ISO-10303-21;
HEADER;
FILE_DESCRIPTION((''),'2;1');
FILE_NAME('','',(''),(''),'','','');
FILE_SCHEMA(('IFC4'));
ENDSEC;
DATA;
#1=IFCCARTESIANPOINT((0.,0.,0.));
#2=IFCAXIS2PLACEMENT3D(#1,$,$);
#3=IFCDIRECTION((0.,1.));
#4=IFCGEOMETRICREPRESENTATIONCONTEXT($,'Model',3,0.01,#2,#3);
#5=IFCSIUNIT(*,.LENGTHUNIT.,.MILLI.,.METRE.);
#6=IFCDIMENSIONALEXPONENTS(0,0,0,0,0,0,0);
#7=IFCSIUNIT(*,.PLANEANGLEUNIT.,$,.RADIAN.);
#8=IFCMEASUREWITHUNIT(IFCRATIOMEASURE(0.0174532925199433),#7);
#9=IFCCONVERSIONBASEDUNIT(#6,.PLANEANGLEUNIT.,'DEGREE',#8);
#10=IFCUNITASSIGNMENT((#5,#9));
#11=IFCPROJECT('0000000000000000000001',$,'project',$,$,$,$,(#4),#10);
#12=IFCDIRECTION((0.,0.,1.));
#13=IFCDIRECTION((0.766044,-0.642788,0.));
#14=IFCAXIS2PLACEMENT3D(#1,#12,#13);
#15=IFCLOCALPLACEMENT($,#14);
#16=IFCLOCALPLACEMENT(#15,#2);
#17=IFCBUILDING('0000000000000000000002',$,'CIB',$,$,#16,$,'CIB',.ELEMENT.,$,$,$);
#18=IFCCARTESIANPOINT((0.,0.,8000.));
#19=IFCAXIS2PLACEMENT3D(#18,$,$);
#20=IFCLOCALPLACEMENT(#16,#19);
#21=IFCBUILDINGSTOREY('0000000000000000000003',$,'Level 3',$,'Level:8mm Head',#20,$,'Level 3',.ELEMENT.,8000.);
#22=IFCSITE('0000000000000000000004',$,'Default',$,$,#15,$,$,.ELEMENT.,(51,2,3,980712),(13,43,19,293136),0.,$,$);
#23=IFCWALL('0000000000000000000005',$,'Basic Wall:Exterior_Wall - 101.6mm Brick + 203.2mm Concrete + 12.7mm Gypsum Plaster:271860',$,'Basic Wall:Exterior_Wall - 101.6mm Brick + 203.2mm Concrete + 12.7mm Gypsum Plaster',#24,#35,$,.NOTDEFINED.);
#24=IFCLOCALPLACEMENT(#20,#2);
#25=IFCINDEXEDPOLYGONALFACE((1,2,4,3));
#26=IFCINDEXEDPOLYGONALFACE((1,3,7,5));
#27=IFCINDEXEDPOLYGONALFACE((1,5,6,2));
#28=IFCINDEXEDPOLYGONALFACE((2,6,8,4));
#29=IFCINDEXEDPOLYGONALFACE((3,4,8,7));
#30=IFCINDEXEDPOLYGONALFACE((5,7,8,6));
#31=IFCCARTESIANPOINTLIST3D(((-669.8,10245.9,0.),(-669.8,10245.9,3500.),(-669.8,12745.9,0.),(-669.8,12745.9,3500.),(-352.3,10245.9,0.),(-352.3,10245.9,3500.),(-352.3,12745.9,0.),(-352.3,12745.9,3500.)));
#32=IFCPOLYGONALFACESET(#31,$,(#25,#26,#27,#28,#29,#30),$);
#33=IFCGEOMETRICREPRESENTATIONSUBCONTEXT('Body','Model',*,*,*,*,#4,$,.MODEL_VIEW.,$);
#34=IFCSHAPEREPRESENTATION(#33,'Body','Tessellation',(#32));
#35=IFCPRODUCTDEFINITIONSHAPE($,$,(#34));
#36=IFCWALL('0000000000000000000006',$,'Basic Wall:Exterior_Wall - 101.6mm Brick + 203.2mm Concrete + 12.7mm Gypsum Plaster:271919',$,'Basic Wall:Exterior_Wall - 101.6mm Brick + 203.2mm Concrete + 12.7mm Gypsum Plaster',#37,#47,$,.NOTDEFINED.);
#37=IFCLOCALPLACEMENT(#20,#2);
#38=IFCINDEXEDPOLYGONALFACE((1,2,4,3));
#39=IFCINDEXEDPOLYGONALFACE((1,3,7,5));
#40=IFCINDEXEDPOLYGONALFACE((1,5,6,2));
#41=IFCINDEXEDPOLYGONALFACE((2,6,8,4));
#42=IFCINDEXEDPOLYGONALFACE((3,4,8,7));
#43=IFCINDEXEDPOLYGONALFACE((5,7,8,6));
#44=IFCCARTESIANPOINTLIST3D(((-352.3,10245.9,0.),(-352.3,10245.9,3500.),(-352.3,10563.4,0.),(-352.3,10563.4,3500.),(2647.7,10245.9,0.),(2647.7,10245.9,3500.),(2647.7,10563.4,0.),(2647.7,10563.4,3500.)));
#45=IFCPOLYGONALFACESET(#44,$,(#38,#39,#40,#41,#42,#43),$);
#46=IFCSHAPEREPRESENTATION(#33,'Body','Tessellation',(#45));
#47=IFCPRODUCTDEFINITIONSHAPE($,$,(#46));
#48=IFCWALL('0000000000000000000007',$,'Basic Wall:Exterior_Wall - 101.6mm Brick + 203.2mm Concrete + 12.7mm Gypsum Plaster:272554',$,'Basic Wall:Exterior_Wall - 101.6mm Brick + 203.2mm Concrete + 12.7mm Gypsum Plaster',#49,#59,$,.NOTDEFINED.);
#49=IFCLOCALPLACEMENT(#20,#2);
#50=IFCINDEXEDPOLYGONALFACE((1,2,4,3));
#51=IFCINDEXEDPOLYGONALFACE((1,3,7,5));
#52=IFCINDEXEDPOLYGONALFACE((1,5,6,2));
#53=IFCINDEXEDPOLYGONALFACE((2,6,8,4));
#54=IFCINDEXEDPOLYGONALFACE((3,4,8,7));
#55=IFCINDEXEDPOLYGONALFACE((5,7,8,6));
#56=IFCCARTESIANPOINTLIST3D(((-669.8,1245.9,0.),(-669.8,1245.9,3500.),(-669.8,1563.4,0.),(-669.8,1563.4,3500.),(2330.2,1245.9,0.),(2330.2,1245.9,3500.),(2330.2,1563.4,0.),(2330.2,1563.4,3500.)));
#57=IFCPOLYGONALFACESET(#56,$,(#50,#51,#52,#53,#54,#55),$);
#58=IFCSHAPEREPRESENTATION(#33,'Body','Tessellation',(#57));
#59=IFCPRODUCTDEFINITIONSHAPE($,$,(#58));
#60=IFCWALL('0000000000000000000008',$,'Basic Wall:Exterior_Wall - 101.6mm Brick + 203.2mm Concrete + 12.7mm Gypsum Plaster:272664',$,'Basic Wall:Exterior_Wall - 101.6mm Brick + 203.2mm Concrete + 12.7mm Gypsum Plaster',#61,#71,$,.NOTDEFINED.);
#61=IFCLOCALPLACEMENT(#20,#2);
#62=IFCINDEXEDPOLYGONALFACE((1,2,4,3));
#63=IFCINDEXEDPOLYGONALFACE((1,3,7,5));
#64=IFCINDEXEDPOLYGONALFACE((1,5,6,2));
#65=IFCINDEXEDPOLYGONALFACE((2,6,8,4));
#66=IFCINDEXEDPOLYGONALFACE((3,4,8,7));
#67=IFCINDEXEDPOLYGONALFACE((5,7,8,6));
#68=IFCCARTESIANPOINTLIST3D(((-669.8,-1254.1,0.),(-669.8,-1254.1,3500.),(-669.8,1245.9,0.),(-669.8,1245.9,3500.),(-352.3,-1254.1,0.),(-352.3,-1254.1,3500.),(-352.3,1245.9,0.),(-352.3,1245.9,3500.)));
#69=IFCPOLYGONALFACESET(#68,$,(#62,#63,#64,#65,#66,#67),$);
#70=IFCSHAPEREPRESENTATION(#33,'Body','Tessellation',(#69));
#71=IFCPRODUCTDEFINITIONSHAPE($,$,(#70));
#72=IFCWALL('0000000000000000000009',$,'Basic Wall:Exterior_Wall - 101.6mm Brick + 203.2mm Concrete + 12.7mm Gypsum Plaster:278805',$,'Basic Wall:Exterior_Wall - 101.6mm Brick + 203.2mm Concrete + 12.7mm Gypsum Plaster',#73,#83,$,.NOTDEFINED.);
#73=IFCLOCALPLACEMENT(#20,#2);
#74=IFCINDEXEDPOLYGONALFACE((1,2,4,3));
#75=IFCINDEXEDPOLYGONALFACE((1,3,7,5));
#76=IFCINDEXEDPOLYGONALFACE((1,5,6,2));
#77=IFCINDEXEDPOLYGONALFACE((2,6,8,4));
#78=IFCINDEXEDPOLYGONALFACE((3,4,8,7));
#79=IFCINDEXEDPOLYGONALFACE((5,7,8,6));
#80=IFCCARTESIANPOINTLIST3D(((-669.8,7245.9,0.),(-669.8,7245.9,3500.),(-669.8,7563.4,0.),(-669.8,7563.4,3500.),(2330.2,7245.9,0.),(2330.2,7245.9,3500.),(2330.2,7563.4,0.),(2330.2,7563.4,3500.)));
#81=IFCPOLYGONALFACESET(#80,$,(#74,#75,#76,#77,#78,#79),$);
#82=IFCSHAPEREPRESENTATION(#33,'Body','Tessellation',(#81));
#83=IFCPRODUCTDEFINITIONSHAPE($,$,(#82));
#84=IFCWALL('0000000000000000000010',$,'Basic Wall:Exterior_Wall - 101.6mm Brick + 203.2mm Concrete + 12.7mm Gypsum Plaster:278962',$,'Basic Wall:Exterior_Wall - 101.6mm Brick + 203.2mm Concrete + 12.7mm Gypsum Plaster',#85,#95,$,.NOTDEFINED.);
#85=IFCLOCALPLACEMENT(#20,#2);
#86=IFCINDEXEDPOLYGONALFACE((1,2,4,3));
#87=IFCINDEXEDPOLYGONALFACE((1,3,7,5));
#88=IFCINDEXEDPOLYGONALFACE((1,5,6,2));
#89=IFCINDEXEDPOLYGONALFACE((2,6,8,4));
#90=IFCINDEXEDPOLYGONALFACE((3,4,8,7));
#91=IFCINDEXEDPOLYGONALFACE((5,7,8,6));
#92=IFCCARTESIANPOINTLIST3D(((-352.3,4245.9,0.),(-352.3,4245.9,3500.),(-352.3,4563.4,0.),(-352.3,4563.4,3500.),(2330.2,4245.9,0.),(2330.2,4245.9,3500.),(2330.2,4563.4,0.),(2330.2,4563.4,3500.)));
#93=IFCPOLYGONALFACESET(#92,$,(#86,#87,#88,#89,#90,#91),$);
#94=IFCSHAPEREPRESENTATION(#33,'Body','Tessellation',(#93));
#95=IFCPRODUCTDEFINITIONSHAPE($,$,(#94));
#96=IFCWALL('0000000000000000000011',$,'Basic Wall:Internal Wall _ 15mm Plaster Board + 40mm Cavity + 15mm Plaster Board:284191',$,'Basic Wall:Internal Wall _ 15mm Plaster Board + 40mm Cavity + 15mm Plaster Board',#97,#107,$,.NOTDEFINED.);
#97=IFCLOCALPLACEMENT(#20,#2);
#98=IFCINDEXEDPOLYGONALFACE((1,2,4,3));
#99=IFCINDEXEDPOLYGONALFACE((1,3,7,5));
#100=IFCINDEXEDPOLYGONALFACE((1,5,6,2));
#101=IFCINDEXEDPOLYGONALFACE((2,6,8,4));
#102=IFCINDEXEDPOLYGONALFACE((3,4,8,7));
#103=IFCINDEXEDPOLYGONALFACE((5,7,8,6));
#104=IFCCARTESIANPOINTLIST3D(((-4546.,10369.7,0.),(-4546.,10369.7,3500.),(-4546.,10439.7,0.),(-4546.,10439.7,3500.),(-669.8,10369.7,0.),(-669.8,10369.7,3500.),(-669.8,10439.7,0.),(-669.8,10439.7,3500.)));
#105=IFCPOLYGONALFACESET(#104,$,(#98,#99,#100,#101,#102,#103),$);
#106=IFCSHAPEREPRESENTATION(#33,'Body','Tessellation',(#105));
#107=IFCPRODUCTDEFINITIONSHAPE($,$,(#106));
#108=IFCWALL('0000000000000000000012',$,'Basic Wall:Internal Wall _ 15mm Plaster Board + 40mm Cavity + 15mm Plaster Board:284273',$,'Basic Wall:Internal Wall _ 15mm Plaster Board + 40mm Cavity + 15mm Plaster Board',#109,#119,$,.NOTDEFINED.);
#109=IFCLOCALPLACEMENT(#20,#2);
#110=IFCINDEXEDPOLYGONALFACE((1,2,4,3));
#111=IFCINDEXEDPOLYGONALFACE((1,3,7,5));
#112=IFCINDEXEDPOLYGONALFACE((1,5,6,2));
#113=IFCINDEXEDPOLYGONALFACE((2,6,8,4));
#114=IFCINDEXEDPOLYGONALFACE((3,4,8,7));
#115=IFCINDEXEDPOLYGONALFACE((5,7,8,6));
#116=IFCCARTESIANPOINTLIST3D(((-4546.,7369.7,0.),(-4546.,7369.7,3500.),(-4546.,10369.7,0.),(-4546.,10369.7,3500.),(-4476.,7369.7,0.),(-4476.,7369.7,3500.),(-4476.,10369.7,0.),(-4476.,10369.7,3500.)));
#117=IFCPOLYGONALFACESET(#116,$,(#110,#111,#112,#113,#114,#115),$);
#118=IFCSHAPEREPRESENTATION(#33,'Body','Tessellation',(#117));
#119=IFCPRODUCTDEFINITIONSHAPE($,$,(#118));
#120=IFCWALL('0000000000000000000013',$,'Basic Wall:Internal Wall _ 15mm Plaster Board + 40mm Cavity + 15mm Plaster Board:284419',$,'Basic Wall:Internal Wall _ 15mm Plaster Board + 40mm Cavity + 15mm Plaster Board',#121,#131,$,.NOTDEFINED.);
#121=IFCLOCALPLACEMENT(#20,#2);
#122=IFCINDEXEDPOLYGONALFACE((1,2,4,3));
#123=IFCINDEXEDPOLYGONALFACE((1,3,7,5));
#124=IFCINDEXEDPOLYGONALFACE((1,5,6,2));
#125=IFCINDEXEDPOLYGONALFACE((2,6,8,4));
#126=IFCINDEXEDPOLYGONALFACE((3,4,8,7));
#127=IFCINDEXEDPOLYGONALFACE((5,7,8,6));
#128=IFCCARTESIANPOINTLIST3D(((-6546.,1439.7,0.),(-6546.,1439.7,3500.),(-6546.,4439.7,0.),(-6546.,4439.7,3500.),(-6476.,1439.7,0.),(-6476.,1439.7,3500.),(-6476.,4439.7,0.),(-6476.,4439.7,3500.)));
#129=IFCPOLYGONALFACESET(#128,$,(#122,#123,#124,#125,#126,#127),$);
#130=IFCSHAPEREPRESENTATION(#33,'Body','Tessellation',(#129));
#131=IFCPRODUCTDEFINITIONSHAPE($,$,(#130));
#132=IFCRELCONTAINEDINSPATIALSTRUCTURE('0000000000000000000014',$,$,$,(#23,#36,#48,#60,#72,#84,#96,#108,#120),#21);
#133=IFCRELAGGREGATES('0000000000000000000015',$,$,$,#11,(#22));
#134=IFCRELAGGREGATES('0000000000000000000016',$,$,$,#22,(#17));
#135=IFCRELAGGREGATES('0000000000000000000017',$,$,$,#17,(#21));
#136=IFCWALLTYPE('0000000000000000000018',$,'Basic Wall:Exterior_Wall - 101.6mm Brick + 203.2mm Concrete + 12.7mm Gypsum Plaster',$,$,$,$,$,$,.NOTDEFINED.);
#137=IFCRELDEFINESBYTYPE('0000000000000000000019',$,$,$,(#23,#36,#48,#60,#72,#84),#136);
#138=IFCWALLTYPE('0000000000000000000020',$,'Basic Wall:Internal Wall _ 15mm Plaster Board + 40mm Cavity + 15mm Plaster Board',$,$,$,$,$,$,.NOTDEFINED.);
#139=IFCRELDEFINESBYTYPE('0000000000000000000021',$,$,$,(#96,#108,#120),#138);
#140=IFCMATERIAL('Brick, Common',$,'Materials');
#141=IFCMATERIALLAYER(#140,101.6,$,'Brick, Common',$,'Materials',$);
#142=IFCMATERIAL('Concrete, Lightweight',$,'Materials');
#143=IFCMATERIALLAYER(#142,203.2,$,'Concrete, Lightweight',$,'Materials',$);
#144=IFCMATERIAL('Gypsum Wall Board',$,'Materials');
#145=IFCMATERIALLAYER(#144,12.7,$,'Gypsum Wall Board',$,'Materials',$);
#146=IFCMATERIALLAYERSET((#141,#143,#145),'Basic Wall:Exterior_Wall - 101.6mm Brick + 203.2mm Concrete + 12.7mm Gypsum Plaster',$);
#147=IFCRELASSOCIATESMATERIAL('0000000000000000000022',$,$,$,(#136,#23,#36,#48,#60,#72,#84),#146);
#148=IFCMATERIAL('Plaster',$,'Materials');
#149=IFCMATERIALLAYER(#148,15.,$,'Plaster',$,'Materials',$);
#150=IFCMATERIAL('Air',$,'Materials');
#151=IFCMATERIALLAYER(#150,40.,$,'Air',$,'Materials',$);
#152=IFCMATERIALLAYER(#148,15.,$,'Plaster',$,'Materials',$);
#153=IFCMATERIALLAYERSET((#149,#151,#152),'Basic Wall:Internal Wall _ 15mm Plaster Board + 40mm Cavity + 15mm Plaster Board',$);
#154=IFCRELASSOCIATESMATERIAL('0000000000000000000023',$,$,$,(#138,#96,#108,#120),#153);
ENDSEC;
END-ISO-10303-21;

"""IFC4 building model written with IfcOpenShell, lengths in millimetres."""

from ifc_helpers import new_model, entity, si_unit, converted_unit, direction, frame, origin, place, context, subcontext, project, spatial, indexed_curve, outline, extrude, material, layer, layer_set, type_object, element, save


model = new_model("IFC4")

# Units and contexts
model_context = context("Model", 3, precision=0.01, world=origin(), true_north=direction((0.0, 1.0)))
body_context = subcontext(model_context, "Body", "Model", "MODEL_VIEW")
ifc_project = project(units=[si_unit("LENGTHUNIT", "METRE", prefix="MILLI"), converted_unit("PLANEANGLEUNIT", "DEGREE", entity("IfcRatioMeasure", 0.0174532925199433), si_unit("PLANEANGLEUNIT", "RADIAN"), dimensions=[0, 0, 0, 0, 0, 0, 0])], contexts=[model_context])

# Site, building, storey
site_placement = place(None, frame((0.0, 0.0, 0.0), z_axis=(0.0, 0.0, 1.0), x_axis=(0.766044, -0.642788, 0.0)))
site = spatial("IfcSite", under=ifc_project, at=site_placement, Name="Default", CompositionType="ELEMENT", RefLatitude=(51, 2, 3, 980712), RefLongitude=(13, 43, 19, 293136), RefElevation=0.0)
building_placement = place(site_placement, origin())
building = spatial("IfcBuilding", under=site, at=building_placement, Name="CIB", LongName="CIB", CompositionType="ELEMENT")
storey_placement = place(building_placement, frame((0.0, 0.0, 8000.0)))
storey = spatial("IfcBuildingStorey", under=building, at=storey_placement, Name="Level 3", ObjectType="Level:8mm Head", LongName="Level 3", CompositionType="ELEMENT", Elevation=8000.0)

# Shared definitions
ifc_material_1 = material(Name="Plaster", Category="Materials")

# Walls
ifc_material_2 = material(Name="Brick, Common", Category="Materials")
ifc_layer_1 = layer(ifc_material_2, 101.6, Name="Brick, Common", Category="Materials")
ifc_material_3 = material(Name="Concrete, Lightweight", Category="Materials")
ifc_layer_2 = layer(ifc_material_3, 203.2, Name="Concrete, Lightweight", Category="Materials")
ifc_material_4 = material(Name="Gypsum Wall Board", Category="Materials")
ifc_layer_3 = layer(ifc_material_4, 12.7, Name="Gypsum Wall Board", Category="Materials")
ifc_layer_set_1 = layer_set([ifc_layer_1, ifc_layer_2, ifc_layer_3], Name="Basic Wall:Exterior_Wall - 101.6mm Brick + 203.2mm Concrete + 12.7mm Gypsum Plaster")
wall_type_1 = type_object("IfcWallType", Name="Basic Wall:Exterior_Wall - 101.6mm Brick + 203.2mm Concrete + 12.7mm Gypsum Plaster", PredefinedType="NOTDEFINED", material=ifc_layer_set_1)
wall_1_placement = place(storey_placement, frame((-511.0, 12745.9, 0.0), z_axis=(0.0, 0.0, 1.0), x_axis=(0.0, -1.0, 0.0)))
element("IfcWall", 1, at=wall_1_placement, inside=storey, type_object=wall_type_1, material=ifc_layer_set_1, Name="Basic Wall:Exterior_Wall - 101.6mm Brick + 203.2mm Concrete + 12.7mm Gypsum Plaster:271860", ObjectType="Basic Wall:Exterior_Wall - 101.6mm Brick + 203.2mm Concrete + 12.7mm Gypsum Plaster", PredefinedType="NOTDEFINED", context=body_context, shape_type="SweptSolid", body=[
    extrude(outline(indexed_curve([(2500.0, 158.8), (0.0, 158.8), (0.0, -158.8), (2500.0, -158.8), (2500.0, 158.8)], self_intersect=False)), origin(), (0.0, 0.0, 1.0), 3500.0),
])
wall_2_placement = place(storey_placement, frame((-352.3, 10404.7, 0.0)))
element("IfcWall", 2, at=wall_2_placement, inside=storey, type_object=wall_type_1, material=ifc_layer_set_1, Name="Basic Wall:Exterior_Wall - 101.6mm Brick + 203.2mm Concrete + 12.7mm Gypsum Plaster:271919", ObjectType="Basic Wall:Exterior_Wall - 101.6mm Brick + 203.2mm Concrete + 12.7mm Gypsum Plaster", PredefinedType="NOTDEFINED", context=body_context, shape_type="SweptSolid", body=[
    extrude(outline(indexed_curve([(3000.0, 158.8), (0.0, 158.8), (0.0, -158.8), (3000.0, -158.8), (3000.0, 158.8)], self_intersect=False)), origin(), (0.0, 0.0, 1.0), 3500.0),
])
wall_3_placement = place(storey_placement, frame((2330.2, 1404.7, 0.0), z_axis=(0.0, 0.0, 1.0), x_axis=(-1.0, 0.0, 0.0)))
element("IfcWall", 3, at=wall_3_placement, inside=storey, type_object=wall_type_1, material=ifc_layer_set_1, Name="Basic Wall:Exterior_Wall - 101.6mm Brick + 203.2mm Concrete + 12.7mm Gypsum Plaster:272554", ObjectType="Basic Wall:Exterior_Wall - 101.6mm Brick + 203.2mm Concrete + 12.7mm Gypsum Plaster", PredefinedType="NOTDEFINED", context=body_context, shape_type="SweptSolid", body=[
    extrude(outline(indexed_curve([(3000.0, 158.8), (0.0, 158.8), (0.0, -158.8), (3000.0, -158.8), (3000.0, 158.8)], self_intersect=False)), origin(), (0.0, 0.0, 1.0), 3500.0),
])
wall_4_placement = place(storey_placement, frame((-511.0, 1245.9, 0.0), z_axis=(0.0, 0.0, 1.0), x_axis=(0.0, -1.0, 0.0)))
element("IfcWall", 4, at=wall_4_placement, inside=storey, type_object=wall_type_1, material=ifc_layer_set_1, Name="Basic Wall:Exterior_Wall - 101.6mm Brick + 203.2mm Concrete + 12.7mm Gypsum Plaster:272664", ObjectType="Basic Wall:Exterior_Wall - 101.6mm Brick + 203.2mm Concrete + 12.7mm Gypsum Plaster", PredefinedType="NOTDEFINED", context=body_context, shape_type="SweptSolid", body=[
    extrude(outline(indexed_curve([(2500.0, 158.8), (0.0, 158.8), (0.0, -158.8), (2500.0, -158.8), (2500.0, 158.8)], self_intersect=False)), origin(), (0.0, 0.0, 1.0), 3500.0),
])
wall_5_placement = place(storey_placement, frame((2330.2, 7404.7, 0.0), z_axis=(0.0, 0.0, 1.0), x_axis=(-1.0, 0.0, 0.0)))
element("IfcWall", 5, at=wall_5_placement, inside=storey, type_object=wall_type_1, material=ifc_layer_set_1, Name="Basic Wall:Exterior_Wall - 101.6mm Brick + 203.2mm Concrete + 12.7mm Gypsum Plaster:278805", ObjectType="Basic Wall:Exterior_Wall - 101.6mm Brick + 203.2mm Concrete + 12.7mm Gypsum Plaster", PredefinedType="NOTDEFINED", context=body_context, shape_type="SweptSolid", body=[
    extrude(outline(indexed_curve([(3000.0, 158.8), (0.0, 158.8), (0.0, -158.8), (3000.0, -158.8), (3000.0, 158.8)], self_intersect=False)), origin(), (0.0, 0.0, 1.0), 3500.0),
])
wall_6_placement = place(storey_placement, frame((-352.3, 4404.7, 0.0)))
element("IfcWall", 6, at=wall_6_placement, inside=storey, type_object=wall_type_1, material=ifc_layer_set_1, Name="Basic Wall:Exterior_Wall - 101.6mm Brick + 203.2mm Concrete + 12.7mm Gypsum Plaster:278962", ObjectType="Basic Wall:Exterior_Wall - 101.6mm Brick + 203.2mm Concrete + 12.7mm Gypsum Plaster", PredefinedType="NOTDEFINED", context=body_context, shape_type="SweptSolid", body=[
    extrude(outline(indexed_curve([(2682.5, 158.8), (0.0, 158.8), (0.0, -158.8), (2682.5, -158.8), (2682.5, 158.8)], self_intersect=False)), origin(), (0.0, 0.0, 1.0), 3500.0),
])
ifc_layer_4 = layer(ifc_material_1, 15.0, Name="Plaster", Category="Materials")
ifc_material_5 = material(Name="Air", Category="Materials")
ifc_layer_5 = layer(ifc_material_5, 40.0, Name="Air", Category="Materials")
ifc_layer_6 = layer(ifc_material_1, 15.0, Name="Plaster", Category="Materials")
ifc_layer_set_2 = layer_set([ifc_layer_4, ifc_layer_5, ifc_layer_6], Name="Basic Wall:Internal Wall _ 15mm Plaster Board + 40mm Cavity + 15mm Plaster Board")
wall_type_2 = type_object("IfcWallType", Name="Basic Wall:Internal Wall _ 15mm Plaster Board + 40mm Cavity + 15mm Plaster Board", PredefinedType="NOTDEFINED", material=ifc_layer_set_2)
wall_7_placement = place(storey_placement, frame((-669.8, 10404.7, 0.0), z_axis=(0.0, 0.0, 1.0), x_axis=(-1.0, 0.0, 0.0)))
element("IfcWall", 7, at=wall_7_placement, inside=storey, type_object=wall_type_2, material=ifc_layer_set_2, Name="Basic Wall:Internal Wall _ 15mm Plaster Board + 40mm Cavity + 15mm Plaster Board:284191", ObjectType="Basic Wall:Internal Wall _ 15mm Plaster Board + 40mm Cavity + 15mm Plaster Board", PredefinedType="NOTDEFINED", context=body_context, shape_type="SweptSolid", body=[
    extrude(outline(indexed_curve([(3876.2, 35.0), (0.0, 35.0), (0.0, -35.0), (3876.2, -35.0), (3876.2, 35.0)], self_intersect=False)), origin(), (0.0, 0.0, 1.0), 3500.0),
])
wall_8_placement = place(storey_placement, frame((-4511.0, 10369.7, 0.0), z_axis=(0.0, 0.0, 1.0), x_axis=(0.0, -1.0, 0.0)))
element("IfcWall", 8, at=wall_8_placement, inside=storey, type_object=wall_type_2, material=ifc_layer_set_2, Name="Basic Wall:Internal Wall _ 15mm Plaster Board + 40mm Cavity + 15mm Plaster Board:284273", ObjectType="Basic Wall:Internal Wall _ 15mm Plaster Board + 40mm Cavity + 15mm Plaster Board", PredefinedType="NOTDEFINED", context=body_context, shape_type="SweptSolid", body=[
    extrude(outline(indexed_curve([(3000.0, 35.0), (0.0, 35.0), (0.0, -35.0), (3000.0, -35.0), (3000.0, 35.0)], self_intersect=False)), origin(), (0.0, 0.0, 1.0), 3500.0),
])
wall_9_placement = place(storey_placement, frame((-6511.0, 1439.7, 0.0), z_axis=(0.0, 0.0, 1.0), x_axis=(0.0, 1.0, 0.0)))
element("IfcWall", 9, at=wall_9_placement, inside=storey, type_object=wall_type_2, material=ifc_layer_set_2, Name="Basic Wall:Internal Wall _ 15mm Plaster Board + 40mm Cavity + 15mm Plaster Board:284419", ObjectType="Basic Wall:Internal Wall _ 15mm Plaster Board + 40mm Cavity + 15mm Plaster Board", PredefinedType="NOTDEFINED", context=body_context, shape_type="SweptSolid", body=[
    extrude(outline(indexed_curve([(3000.0, 35.0), (0.0, 35.0), (0.0, -35.0), (3000.0, -35.0), (3000.0, 35.0)], self_intersect=False)), origin(), (0.0, 0.0, 1.0), 3500.0),
])

save(model, "model.ifc")
